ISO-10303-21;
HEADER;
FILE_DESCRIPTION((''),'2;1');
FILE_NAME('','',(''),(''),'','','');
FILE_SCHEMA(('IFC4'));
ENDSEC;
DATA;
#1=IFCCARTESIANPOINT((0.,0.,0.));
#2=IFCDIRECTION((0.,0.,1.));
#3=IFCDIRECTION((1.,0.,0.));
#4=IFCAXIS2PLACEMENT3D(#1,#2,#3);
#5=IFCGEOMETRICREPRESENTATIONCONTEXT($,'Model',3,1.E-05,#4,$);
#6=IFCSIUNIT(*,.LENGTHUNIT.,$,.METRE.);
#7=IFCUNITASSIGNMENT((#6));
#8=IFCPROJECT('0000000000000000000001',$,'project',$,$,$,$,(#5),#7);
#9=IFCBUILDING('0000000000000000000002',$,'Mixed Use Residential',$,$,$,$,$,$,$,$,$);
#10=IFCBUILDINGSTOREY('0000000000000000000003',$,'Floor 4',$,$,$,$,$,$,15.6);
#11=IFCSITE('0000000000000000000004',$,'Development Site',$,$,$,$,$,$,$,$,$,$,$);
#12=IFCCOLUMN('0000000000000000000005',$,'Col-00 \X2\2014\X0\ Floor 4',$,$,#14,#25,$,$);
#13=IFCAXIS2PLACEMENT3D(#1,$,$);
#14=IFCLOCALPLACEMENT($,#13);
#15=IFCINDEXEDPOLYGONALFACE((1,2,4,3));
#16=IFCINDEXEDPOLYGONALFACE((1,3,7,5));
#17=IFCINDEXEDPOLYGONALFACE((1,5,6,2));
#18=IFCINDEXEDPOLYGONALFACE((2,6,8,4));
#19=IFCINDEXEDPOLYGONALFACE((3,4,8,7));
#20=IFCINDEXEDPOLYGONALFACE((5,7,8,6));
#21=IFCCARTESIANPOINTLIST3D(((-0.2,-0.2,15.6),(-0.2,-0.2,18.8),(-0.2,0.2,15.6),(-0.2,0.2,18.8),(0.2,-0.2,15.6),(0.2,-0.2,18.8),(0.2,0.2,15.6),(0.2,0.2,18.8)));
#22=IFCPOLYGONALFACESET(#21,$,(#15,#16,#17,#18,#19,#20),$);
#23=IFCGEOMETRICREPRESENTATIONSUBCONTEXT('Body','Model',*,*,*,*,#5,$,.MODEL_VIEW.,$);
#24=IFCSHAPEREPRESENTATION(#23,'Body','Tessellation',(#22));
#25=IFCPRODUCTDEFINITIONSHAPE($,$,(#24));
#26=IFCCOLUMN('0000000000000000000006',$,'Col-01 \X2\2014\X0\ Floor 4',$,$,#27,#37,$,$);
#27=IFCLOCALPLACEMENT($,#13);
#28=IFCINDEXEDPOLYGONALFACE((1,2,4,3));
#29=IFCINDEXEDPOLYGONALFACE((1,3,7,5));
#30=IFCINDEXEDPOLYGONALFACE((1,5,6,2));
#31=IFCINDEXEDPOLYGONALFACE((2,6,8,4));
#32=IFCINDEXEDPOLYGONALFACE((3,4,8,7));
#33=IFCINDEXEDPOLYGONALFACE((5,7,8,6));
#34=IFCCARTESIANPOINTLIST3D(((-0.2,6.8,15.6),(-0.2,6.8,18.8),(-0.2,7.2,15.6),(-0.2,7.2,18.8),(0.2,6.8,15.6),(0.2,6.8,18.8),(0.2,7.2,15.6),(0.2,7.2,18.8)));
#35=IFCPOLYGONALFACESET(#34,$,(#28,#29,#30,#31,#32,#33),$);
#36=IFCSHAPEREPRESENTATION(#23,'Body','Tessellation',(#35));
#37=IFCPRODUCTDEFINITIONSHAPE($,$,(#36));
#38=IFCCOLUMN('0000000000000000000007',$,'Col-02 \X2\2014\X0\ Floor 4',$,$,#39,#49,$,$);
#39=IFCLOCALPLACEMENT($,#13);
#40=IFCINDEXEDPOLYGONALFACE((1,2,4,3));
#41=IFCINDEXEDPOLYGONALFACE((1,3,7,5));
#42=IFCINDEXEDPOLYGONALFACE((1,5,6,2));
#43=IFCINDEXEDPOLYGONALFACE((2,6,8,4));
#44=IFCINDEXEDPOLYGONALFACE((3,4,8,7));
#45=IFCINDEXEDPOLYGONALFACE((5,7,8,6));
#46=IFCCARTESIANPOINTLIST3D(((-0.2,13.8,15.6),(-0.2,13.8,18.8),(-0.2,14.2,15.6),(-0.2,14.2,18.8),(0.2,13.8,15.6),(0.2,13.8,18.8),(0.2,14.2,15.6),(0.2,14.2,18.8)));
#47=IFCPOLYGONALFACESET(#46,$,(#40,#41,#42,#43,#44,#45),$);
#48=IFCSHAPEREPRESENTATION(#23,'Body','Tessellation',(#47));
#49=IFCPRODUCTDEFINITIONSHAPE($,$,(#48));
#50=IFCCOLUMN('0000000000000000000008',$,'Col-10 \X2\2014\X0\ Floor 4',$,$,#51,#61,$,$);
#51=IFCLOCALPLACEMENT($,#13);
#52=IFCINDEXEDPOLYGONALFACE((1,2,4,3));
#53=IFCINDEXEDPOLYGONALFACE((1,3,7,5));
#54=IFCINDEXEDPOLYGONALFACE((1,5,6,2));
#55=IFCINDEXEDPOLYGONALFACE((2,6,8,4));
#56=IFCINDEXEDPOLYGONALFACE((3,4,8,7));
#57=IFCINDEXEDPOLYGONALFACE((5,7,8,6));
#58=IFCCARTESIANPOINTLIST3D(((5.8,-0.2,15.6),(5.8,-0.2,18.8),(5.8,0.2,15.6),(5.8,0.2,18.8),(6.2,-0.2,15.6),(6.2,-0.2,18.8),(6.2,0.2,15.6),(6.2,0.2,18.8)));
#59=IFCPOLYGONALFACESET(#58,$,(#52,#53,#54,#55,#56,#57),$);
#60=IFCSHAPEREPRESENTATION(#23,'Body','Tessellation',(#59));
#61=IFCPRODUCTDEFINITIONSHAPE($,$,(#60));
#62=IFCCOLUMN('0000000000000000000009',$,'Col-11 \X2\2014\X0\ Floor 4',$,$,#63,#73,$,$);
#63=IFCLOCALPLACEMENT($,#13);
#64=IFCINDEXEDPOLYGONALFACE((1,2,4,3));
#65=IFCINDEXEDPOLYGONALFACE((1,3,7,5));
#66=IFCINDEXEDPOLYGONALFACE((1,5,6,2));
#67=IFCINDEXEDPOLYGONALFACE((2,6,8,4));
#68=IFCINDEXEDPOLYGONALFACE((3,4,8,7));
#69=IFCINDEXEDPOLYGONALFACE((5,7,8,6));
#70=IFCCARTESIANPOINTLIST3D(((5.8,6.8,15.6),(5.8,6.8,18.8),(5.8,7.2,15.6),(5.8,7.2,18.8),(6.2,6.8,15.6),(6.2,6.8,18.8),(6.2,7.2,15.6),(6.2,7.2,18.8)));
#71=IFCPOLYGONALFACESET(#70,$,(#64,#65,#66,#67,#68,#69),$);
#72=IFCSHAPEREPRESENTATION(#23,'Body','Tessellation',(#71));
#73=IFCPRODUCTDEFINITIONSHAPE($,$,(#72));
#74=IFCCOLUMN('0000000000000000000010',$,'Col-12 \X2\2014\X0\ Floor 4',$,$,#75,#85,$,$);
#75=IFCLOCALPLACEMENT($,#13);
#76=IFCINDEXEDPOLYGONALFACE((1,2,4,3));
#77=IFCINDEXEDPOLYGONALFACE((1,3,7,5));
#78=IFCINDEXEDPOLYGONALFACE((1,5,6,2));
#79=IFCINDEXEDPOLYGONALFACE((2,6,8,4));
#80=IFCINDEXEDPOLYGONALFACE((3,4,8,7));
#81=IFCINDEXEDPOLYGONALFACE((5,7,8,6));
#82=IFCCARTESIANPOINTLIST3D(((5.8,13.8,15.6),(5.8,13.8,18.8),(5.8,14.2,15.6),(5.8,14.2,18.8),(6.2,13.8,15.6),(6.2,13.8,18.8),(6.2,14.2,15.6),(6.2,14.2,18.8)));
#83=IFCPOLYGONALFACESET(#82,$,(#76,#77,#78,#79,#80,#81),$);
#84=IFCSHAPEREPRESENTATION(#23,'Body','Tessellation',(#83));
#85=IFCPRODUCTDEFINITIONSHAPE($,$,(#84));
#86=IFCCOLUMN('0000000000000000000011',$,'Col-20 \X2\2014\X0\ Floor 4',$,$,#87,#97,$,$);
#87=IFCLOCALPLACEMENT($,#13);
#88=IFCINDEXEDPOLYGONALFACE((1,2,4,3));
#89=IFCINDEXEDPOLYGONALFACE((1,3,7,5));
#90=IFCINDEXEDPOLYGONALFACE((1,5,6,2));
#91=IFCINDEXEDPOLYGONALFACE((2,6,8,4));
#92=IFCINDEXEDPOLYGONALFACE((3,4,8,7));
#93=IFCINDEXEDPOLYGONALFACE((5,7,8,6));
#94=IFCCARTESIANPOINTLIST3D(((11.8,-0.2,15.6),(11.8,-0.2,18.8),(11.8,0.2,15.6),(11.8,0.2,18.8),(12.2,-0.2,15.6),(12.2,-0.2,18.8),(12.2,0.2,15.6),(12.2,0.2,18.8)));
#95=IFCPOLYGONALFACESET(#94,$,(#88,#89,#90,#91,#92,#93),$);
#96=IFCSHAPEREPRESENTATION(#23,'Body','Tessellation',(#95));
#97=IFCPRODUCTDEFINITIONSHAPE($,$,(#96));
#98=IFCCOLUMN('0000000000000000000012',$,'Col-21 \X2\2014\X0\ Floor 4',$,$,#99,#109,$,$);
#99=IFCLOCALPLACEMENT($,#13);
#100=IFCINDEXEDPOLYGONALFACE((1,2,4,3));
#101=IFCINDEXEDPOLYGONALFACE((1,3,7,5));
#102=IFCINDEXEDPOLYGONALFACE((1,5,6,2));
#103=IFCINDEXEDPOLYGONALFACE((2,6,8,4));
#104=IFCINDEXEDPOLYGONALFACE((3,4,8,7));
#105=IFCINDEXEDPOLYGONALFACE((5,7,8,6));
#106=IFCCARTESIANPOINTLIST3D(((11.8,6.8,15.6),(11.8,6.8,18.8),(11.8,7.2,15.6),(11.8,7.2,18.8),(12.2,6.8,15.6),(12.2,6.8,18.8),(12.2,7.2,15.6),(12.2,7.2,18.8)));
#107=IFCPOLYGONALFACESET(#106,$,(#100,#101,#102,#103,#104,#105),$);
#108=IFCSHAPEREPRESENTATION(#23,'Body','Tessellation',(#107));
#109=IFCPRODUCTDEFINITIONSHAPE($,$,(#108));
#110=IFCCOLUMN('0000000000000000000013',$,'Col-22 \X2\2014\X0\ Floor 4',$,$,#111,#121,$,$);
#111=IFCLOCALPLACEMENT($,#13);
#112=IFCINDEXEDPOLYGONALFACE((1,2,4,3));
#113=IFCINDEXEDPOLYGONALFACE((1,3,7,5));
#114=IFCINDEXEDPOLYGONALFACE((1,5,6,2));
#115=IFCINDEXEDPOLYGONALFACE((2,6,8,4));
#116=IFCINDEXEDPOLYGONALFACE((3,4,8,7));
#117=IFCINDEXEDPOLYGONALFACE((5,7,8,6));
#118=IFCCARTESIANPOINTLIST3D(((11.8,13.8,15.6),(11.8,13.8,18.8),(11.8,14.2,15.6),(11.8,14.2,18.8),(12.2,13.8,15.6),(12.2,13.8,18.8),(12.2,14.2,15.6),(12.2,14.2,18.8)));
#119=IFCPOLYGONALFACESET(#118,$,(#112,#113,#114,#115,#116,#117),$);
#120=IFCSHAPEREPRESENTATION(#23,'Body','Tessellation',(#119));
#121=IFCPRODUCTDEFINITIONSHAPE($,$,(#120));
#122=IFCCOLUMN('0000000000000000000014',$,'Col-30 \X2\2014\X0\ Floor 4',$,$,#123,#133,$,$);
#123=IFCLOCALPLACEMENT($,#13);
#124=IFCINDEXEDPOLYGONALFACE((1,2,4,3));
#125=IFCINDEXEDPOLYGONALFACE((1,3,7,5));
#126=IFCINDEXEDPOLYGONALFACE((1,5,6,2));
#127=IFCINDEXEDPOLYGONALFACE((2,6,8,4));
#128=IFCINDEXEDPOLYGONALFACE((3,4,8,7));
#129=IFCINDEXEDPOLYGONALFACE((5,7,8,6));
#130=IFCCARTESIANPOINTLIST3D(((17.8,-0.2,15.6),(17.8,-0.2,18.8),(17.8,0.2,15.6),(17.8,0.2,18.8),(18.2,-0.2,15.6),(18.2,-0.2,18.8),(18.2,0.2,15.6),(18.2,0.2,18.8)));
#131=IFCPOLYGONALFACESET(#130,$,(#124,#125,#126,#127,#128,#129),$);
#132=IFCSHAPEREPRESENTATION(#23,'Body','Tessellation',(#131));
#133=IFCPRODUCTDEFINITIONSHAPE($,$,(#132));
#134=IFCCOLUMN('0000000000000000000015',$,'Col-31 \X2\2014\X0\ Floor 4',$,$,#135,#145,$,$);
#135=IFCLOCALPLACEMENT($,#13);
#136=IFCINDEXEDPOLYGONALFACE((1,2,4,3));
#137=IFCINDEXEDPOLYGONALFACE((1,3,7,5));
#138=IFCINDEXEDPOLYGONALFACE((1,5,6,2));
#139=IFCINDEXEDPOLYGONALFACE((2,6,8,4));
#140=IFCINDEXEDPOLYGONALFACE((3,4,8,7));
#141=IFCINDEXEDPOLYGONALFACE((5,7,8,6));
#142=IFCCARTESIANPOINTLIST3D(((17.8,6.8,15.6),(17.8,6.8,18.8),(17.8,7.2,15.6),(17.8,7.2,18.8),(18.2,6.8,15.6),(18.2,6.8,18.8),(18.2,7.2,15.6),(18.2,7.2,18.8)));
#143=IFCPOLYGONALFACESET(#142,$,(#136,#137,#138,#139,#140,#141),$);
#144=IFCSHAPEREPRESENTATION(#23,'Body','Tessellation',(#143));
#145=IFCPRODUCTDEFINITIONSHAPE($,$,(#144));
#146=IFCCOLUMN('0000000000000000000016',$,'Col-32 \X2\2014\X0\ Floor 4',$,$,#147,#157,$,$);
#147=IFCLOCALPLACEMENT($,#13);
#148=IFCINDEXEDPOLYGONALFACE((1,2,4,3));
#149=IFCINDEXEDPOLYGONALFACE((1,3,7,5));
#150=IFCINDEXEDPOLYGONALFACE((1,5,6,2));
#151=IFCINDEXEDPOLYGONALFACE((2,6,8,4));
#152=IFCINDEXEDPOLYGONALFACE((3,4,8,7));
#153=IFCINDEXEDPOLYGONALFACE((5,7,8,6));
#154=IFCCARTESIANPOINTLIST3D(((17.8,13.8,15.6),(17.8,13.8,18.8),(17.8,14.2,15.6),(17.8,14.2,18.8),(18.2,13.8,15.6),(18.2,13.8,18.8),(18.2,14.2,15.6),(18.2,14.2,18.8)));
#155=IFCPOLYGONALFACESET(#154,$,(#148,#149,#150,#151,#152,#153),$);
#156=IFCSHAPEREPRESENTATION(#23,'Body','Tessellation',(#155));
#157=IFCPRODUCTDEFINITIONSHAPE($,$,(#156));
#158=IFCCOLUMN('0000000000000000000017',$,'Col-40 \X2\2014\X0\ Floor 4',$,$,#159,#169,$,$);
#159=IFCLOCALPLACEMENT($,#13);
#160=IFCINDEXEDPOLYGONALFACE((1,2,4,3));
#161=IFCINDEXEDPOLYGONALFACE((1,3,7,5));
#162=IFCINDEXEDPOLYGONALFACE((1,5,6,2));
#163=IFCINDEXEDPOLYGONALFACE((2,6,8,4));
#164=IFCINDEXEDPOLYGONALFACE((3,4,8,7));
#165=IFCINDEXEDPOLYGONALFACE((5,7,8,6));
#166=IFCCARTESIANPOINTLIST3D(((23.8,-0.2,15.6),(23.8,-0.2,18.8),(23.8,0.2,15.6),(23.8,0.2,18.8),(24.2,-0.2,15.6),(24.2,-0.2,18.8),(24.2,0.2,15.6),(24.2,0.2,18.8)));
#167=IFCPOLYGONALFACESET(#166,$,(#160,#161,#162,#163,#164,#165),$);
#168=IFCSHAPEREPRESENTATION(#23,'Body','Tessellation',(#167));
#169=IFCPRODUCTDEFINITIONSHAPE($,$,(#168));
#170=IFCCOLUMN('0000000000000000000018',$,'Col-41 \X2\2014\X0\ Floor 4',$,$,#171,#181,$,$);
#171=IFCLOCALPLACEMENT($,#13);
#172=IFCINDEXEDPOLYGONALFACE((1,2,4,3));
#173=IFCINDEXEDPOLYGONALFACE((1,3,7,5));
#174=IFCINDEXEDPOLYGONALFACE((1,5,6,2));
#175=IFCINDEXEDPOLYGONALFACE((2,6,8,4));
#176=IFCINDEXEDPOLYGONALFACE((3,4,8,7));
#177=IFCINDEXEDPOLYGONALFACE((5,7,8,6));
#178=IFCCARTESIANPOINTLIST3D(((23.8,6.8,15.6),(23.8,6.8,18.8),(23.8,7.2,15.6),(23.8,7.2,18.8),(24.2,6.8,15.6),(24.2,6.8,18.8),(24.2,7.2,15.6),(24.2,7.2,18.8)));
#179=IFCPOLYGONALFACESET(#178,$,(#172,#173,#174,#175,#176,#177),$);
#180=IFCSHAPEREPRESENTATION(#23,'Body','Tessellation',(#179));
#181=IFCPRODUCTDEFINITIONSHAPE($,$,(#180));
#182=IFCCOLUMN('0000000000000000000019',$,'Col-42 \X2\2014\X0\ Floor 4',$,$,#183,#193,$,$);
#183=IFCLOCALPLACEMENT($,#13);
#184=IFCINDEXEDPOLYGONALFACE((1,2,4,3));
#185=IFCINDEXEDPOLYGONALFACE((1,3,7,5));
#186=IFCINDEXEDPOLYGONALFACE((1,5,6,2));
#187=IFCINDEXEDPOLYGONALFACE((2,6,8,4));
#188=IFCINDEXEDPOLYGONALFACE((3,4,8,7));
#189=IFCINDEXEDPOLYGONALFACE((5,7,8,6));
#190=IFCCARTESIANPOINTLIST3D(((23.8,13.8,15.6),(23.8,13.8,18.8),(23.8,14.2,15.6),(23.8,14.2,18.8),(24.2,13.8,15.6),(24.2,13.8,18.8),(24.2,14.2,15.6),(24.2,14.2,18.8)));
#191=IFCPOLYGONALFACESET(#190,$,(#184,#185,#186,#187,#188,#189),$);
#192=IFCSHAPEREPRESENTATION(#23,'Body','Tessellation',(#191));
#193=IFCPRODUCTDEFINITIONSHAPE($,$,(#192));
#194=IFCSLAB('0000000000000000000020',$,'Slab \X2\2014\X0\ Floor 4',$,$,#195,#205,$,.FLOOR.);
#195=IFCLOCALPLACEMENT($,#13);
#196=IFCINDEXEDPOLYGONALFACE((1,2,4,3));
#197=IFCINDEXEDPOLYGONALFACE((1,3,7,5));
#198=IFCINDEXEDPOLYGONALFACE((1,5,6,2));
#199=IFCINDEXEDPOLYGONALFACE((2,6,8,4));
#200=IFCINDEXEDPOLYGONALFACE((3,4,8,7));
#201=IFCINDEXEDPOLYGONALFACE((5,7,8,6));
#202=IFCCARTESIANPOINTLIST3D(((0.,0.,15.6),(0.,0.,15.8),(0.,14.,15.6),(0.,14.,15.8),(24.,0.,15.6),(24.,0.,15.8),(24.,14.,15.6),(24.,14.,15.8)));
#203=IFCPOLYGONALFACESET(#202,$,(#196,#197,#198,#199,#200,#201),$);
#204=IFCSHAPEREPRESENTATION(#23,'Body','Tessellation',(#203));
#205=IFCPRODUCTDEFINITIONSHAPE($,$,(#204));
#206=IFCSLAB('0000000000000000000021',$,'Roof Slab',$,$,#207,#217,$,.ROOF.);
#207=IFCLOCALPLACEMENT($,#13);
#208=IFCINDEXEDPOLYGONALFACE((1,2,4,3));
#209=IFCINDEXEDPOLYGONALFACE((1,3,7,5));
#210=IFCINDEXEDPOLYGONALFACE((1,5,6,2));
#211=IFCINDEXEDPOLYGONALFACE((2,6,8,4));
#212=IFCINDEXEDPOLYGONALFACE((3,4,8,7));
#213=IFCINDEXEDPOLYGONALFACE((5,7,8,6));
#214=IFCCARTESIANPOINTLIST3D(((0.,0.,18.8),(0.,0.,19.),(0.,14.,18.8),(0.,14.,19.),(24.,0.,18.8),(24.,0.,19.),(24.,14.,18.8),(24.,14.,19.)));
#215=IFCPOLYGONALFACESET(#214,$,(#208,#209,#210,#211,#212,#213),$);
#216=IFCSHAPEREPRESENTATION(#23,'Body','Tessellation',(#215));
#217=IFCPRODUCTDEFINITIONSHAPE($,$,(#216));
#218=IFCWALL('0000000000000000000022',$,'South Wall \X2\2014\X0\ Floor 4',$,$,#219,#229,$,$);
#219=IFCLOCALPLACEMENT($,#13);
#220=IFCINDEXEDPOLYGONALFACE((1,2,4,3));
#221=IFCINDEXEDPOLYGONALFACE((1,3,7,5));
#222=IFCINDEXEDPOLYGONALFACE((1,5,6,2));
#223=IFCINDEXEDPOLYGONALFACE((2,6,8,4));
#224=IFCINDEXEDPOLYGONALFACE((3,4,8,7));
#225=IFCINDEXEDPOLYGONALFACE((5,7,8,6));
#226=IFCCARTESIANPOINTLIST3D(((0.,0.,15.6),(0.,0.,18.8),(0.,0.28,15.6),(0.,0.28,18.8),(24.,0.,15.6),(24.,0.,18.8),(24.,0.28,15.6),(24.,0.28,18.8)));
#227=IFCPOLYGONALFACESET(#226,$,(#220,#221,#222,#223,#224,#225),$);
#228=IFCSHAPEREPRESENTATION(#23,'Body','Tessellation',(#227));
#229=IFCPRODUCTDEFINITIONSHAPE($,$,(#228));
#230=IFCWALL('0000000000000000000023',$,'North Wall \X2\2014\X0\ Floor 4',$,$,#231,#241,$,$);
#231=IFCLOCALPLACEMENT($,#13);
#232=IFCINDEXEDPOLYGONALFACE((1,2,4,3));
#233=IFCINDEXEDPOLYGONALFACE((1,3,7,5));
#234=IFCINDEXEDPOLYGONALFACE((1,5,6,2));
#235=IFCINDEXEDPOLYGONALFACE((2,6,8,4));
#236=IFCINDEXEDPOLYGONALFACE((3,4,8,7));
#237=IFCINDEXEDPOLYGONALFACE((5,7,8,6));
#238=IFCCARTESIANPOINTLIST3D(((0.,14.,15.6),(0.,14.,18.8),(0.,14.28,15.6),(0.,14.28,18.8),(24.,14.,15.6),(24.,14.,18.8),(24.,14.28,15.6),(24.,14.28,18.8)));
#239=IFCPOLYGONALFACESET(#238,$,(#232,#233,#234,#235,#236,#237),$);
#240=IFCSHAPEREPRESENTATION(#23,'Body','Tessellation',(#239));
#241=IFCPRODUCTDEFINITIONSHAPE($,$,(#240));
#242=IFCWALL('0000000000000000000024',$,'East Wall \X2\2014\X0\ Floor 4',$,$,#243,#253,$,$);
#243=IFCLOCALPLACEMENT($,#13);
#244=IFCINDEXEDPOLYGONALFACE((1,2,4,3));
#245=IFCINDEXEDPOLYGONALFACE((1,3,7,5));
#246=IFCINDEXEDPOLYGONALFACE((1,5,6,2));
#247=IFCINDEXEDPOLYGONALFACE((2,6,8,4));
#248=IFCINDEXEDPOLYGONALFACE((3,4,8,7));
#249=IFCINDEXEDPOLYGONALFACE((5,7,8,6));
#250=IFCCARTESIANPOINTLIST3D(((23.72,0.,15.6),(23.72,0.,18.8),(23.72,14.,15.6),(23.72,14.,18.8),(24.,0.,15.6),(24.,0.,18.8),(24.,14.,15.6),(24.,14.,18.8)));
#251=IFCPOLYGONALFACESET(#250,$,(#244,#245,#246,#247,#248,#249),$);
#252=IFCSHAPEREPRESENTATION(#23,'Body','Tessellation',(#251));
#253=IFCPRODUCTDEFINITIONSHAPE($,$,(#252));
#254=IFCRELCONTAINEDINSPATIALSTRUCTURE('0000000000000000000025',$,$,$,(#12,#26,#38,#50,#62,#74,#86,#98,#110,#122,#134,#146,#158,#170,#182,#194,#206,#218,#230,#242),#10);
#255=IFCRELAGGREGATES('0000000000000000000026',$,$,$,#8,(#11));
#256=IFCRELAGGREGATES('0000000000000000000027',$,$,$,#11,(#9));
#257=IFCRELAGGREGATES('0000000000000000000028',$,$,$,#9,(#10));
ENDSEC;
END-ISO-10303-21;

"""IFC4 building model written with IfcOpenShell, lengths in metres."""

from ifc_helpers import new_model, si_unit, frame, origin_with_axes, place, context, subcontext, project, spatial, indexed_curve, rectangle, outline, extrude, element, save


model = new_model("IFC4")

# Units and contexts
model_context = context("Model", 3, precision=1e-05, world=origin_with_axes())
body_context = subcontext(model_context, "Body", "Model", "MODEL_VIEW")
ifc_project = project(units=[si_unit("LENGTHUNIT", "METRE")], contexts=[model_context])

# Site, building, storey
site = spatial("IfcSite", under=ifc_project, Name="Development Site")
building = spatial("IfcBuilding", under=site, Name="Mixed Use Residential")
storey = spatial("IfcBuildingStorey", under=building, Name="Floor 4", Elevation=15.6)

# Columns
for number, where, z_axis, x_axis, name in (
    (1, (0.0, 0.0, 15.6), (0.0, 0.0, 1.0), (1.0, 0.0, 0.0), "Col-00 — Floor 4"),
    (2, (0.0, 7.0, 15.6), (0.0, 0.0, 1.0), (1.0, 0.0, 0.0), "Col-01 — Floor 4"),
    (3, (0.0, 14.0, 15.6), (0.0, 0.0, 1.0), (1.0, 0.0, 0.0), "Col-02 — Floor 4"),
    (4, (6.0, 0.0, 15.6), (0.0, 0.0, 1.0), (1.0, 0.0, 0.0), "Col-10 — Floor 4"),
    (5, (6.0, 7.0, 15.6), (0.0, 0.0, 1.0), (1.0, 0.0, 0.0), "Col-11 — Floor 4"),
    (6, (6.0, 14.0, 15.6), (0.0, 0.0, 1.0), (1.0, 0.0, 0.0), "Col-12 — Floor 4"),
    (7, (12.0, 0.0, 15.6), (0.0, 0.0, 1.0), (1.0, 0.0, 0.0), "Col-20 — Floor 4"),
    (8, (12.0, 7.0, 15.6), (0.0, 0.0, 1.0), (1.0, 0.0, 0.0), "Col-21 — Floor 4"),
    (9, (12.0, 14.0, 15.6), (0.0, 0.0, 1.0), (1.0, 0.0, 0.0), "Col-22 — Floor 4"),
    (10, (18.0, 0.0, 15.6), (0.0, 0.0, 1.0), (1.0, 0.0, 0.0), "Col-30 — Floor 4"),
    (11, (18.0, 7.0, 15.6), (0.0, 0.0, 1.0), (1.0, 0.0, 0.0), "Col-31 — Floor 4"),
    (12, (18.0, 14.0, 15.6), (0.0, 0.0, 1.0), (1.0, 0.0, 0.0), "Col-32 — Floor 4"),
    (13, (24.0, 0.0, 15.6), (0.0, 0.0, 1.0), (1.0, 0.0, 0.0), "Col-40 — Floor 4"),
    (14, (24.0, 7.0, 15.6), (0.0, 0.0, 1.0), (1.0, 0.0, 0.0), "Col-41 — Floor 4"),
    (15, (24.0, 14.0, 15.6), (0.0, 0.0, 1.0), (1.0, 0.0, 0.0), "Col-42 — Floor 4"),
):
    element("IfcColumn", number, at=place(None, frame(where, z_axis=z_axis, x_axis=x_axis)), inside=storey, Name=name, context=body_context, shape_type="SweptSolid", body=[
        extrude(rectangle(XDim=0.4, YDim=0.4), origin_with_axes(), (0.0, 0.0, 1.0), 3.2),
    ])

# Slabs
slab_1_placement = place(None, frame((0.0, 0.0, 15.6), z_axis=(0.0, 0.0, 1.0), x_axis=(1.0, 0.0, 0.0)))
element("IfcSlab", 16, at=slab_1_placement, inside=storey, Name="Slab — Floor 4", PredefinedType="FLOOR", context=body_context, shape_type="SweptSolid", body=[
    extrude(outline(indexed_curve([(0.0, 0.0), (24.0, 0.0), (24.0, 14.0), (0.0, 14.0), (0.0, 0.0)])), None, (0.0, 0.0, 1.0), 0.2),
])
slab_2_placement = place(None, frame((0.0, 0.0, 18.8), z_axis=(0.0, 0.0, 1.0), x_axis=(1.0, 0.0, 0.0)))
element("IfcSlab", 17, at=slab_2_placement, inside=storey, Name="Roof Slab", PredefinedType="ROOF", context=body_context, shape_type="SweptSolid", body=[
    extrude(outline(indexed_curve([(0.0, 0.0), (24.0, 0.0), (24.0, 14.0), (0.0, 14.0), (0.0, 0.0)])), None, (0.0, 0.0, 1.0), 0.2),
])

# Walls
for number, where, z_axis, x_axis, name in (
    (18, (0.0, 0.0, 15.6), (0.0, 0.0, 1.0), (1.0, 0.0, 0.0), "South Wall — Floor 4"),
    (19, (0.0, 14.0, 15.6), (0.0, 0.0, 1.0), (1.0, 0.0, 0.0), "North Wall — Floor 4"),
):
    element("IfcWall", number, at=place(None, frame(where, z_axis=z_axis, x_axis=x_axis)), inside=storey, Name=name, context=body_context, shape_type="SweptSolid", body=[
        extrude(outline(indexed_curve([(0.0, 0.0), (0.0, 0.28), (24.0, 0.28), (24.0, 0.0), (0.0, 0.0)], self_intersect=False)), origin_with_axes(), (0.0, 0.0, 1.0), 3.2),
    ])
for number, where, z_axis, x_axis, name in (
    (20, (24.0, 0.0, 15.6), (0.0, 0.0, 1.0), (0.0, 1.0, 0.0), "East Wall — Floor 4"),
):
    element("IfcWall", number, at=place(None, frame(where, z_axis=z_axis, x_axis=x_axis)), inside=storey, Name=name, context=body_context, shape_type="SweptSolid", body=[
        extrude(outline(indexed_curve([(0.0, 0.0), (0.0, 0.28), (14.0, 0.28), (14.0, 0.0), (0.0, 0.0)], self_intersect=False)), origin_with_axes(), (0.0, 0.0, 1.0), 3.2),
    ])

save(model, "model.ifc")
